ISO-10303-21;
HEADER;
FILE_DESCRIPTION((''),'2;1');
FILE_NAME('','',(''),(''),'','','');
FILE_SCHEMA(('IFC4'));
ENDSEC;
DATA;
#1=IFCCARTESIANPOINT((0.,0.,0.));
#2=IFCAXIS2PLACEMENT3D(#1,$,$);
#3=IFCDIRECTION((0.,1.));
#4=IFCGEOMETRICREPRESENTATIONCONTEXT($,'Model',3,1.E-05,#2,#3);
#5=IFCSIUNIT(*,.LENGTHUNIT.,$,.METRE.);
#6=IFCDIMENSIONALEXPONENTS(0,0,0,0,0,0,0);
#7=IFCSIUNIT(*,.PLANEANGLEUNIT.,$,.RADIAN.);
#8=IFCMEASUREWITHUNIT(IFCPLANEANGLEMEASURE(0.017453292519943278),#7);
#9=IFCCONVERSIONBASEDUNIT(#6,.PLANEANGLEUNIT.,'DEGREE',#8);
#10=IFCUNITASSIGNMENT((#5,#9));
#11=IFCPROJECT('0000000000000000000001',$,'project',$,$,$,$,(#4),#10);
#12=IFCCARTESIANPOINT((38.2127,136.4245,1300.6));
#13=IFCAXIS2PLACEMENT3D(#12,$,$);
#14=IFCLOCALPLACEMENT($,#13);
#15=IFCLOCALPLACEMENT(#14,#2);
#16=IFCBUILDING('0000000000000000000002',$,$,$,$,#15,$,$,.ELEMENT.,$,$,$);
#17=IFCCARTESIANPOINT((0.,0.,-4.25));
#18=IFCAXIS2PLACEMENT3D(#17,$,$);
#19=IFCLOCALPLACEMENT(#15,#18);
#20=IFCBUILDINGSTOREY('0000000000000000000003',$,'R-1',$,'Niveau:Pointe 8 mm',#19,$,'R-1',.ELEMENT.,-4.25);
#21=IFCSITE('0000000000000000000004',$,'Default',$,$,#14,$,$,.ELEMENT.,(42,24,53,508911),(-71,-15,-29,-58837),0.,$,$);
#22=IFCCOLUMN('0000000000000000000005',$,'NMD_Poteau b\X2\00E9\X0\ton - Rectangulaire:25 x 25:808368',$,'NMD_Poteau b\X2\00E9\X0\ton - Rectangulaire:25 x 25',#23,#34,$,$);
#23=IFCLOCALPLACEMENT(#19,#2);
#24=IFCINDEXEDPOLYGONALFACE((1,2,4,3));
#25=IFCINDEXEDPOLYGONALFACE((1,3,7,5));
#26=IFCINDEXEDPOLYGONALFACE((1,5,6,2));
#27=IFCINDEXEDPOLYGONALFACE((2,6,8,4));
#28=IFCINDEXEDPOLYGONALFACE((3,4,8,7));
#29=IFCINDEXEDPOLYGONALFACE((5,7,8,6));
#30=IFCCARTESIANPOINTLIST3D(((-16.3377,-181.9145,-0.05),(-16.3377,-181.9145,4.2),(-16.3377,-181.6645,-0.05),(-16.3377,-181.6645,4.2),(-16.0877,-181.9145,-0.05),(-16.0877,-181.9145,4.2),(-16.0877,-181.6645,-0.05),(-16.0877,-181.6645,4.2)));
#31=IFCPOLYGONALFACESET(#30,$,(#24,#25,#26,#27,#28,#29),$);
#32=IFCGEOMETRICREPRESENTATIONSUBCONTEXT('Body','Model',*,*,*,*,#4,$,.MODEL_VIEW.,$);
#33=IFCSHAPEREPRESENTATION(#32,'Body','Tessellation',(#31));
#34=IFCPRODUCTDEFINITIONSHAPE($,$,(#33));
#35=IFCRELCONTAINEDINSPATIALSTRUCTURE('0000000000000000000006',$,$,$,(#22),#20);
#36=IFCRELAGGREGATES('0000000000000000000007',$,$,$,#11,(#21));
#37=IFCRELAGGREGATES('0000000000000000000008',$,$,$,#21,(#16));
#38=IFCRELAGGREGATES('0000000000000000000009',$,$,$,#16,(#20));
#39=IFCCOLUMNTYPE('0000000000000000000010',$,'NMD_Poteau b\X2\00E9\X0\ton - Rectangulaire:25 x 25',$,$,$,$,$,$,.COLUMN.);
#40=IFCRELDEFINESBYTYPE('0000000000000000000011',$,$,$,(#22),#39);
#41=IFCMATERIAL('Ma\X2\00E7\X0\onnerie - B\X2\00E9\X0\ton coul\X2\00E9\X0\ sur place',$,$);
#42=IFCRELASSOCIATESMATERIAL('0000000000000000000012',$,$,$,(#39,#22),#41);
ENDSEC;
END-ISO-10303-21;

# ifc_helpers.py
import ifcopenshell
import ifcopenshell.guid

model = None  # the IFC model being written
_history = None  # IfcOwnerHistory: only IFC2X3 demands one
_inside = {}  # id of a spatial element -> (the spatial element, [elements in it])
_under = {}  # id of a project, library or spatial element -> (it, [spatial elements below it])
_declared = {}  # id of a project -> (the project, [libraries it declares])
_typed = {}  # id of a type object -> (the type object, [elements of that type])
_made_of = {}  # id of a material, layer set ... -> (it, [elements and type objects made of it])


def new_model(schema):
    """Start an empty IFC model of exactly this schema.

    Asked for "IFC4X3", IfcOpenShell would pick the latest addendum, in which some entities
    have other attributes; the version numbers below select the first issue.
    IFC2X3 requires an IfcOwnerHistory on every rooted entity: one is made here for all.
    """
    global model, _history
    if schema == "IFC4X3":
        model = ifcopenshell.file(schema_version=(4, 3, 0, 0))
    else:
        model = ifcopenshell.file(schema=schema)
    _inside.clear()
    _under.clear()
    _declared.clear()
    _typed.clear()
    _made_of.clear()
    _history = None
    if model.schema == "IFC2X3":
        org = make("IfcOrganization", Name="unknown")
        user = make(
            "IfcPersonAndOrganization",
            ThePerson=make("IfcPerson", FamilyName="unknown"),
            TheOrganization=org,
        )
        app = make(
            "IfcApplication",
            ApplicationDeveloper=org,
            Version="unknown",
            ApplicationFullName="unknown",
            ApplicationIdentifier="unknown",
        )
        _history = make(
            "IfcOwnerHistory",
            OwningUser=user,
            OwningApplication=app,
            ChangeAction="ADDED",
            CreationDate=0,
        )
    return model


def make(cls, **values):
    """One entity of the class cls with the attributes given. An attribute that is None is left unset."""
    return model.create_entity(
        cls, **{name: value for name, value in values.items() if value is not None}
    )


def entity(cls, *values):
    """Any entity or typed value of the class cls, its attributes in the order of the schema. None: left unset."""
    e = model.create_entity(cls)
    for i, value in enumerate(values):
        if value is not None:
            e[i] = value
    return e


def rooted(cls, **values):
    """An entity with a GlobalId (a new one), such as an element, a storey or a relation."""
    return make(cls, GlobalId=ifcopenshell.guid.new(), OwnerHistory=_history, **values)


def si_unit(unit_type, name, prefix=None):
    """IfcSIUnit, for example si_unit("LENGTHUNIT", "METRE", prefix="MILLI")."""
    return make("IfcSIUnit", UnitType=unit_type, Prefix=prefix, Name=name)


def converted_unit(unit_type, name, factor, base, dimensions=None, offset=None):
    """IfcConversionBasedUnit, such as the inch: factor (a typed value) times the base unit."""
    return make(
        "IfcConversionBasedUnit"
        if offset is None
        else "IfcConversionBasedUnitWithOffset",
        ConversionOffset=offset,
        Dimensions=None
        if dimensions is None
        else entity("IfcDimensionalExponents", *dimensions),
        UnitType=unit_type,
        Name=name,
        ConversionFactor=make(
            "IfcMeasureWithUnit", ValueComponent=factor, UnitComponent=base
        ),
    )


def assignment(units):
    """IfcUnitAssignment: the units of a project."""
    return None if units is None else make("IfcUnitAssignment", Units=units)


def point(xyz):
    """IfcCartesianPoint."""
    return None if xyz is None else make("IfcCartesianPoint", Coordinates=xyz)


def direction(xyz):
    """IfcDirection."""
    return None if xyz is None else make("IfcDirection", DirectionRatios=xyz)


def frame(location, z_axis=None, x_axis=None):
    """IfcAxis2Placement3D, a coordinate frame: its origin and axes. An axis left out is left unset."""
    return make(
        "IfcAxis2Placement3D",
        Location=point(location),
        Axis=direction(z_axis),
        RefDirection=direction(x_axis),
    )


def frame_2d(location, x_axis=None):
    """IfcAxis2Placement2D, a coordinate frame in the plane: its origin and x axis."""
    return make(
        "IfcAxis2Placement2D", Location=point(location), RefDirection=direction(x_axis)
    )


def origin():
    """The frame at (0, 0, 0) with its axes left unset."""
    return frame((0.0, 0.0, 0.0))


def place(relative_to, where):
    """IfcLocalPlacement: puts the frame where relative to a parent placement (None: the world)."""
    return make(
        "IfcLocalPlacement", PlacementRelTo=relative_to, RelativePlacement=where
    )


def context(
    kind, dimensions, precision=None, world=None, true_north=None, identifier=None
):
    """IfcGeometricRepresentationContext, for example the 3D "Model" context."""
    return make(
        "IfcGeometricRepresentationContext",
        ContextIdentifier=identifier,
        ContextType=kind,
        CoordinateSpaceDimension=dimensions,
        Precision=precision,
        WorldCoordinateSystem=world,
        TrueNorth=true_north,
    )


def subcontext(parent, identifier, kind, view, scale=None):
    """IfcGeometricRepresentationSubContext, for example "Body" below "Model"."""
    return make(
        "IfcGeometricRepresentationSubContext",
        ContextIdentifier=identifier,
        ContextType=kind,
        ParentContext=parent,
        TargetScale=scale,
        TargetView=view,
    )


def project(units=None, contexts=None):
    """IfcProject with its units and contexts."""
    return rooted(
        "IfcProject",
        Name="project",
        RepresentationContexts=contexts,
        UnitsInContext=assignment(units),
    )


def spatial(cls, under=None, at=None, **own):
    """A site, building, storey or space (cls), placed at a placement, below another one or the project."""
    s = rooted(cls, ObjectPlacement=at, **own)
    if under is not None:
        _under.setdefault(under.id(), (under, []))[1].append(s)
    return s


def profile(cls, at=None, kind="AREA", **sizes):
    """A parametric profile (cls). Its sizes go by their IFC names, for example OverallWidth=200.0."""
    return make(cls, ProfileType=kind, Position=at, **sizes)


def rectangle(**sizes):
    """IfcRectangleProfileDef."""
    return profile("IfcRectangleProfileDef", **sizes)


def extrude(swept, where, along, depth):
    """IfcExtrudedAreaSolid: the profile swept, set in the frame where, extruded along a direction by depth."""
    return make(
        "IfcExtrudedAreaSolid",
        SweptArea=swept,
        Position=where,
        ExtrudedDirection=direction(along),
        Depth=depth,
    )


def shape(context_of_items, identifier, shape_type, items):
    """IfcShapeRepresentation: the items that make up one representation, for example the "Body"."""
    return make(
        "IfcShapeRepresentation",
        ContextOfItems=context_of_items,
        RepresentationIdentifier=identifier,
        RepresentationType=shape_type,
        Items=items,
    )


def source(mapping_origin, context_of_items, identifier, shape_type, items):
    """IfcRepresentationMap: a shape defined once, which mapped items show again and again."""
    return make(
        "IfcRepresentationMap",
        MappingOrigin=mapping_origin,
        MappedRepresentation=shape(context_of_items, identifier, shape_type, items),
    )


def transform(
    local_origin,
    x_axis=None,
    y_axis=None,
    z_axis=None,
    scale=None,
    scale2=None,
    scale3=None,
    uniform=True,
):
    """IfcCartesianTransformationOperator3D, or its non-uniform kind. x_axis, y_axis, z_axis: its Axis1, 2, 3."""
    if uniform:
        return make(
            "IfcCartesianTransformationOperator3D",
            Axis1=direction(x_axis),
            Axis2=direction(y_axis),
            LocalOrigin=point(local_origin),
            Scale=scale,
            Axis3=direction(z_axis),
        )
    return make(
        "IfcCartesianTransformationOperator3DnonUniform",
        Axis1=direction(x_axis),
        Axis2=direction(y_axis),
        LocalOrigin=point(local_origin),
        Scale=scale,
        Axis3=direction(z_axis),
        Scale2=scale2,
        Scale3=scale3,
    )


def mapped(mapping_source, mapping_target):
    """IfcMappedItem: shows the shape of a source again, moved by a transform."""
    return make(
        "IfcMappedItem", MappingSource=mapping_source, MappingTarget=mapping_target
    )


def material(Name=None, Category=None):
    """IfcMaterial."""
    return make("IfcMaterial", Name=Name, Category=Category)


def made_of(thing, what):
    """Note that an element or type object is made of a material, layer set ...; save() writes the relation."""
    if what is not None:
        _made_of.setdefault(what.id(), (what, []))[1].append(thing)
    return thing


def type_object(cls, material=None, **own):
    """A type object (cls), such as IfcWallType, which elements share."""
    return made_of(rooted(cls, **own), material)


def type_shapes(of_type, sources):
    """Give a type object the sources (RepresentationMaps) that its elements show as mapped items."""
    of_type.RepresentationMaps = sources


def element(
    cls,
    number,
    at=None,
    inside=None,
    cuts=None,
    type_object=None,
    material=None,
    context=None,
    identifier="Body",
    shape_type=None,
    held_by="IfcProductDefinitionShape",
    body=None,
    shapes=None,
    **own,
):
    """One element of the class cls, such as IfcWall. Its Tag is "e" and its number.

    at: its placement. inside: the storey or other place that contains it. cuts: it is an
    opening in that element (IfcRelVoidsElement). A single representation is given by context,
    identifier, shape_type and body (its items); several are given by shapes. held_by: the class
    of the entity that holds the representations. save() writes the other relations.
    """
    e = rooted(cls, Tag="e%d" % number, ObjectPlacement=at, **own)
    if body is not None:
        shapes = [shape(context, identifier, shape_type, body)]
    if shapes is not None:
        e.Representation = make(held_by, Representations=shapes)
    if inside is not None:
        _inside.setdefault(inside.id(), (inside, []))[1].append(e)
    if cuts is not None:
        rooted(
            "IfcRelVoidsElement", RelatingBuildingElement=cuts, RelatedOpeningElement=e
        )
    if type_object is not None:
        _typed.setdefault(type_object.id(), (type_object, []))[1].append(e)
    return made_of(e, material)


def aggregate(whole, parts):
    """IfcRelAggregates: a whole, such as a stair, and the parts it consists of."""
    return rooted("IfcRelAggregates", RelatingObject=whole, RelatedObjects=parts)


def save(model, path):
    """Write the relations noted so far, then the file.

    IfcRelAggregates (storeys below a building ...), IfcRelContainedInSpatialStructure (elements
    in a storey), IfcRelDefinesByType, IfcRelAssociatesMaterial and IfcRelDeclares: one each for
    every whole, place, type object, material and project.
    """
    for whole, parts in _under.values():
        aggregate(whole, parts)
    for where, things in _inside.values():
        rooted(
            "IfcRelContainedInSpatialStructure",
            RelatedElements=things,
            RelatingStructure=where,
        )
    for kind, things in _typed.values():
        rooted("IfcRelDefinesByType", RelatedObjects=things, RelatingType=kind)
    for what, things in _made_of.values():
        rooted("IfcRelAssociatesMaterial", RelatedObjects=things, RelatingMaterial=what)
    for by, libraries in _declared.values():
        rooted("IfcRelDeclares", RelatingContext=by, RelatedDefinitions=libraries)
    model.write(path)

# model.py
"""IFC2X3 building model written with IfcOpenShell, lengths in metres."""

from ifc_helpers import new_model, entity, si_unit, converted_unit, direction, frame, frame_2d, origin, place, context, subcontext, project, spatial, rectangle, extrude, source, transform, mapped, material, type_object, type_shapes, element, save


model = new_model("IFC2X3")

# Units and contexts
model_context = context("Model", 3, precision=1e-05, world=origin(), true_north=direction((0.0, 1.0)))
body_context = subcontext(model_context, "Body", "Model", "MODEL_VIEW")
ifc_project = project(units=[si_unit("LENGTHUNIT", "METRE"), converted_unit("PLANEANGLEUNIT", "DEGREE", entity("IfcPlaneAngleMeasure", 0.017453292519943278), si_unit("PLANEANGLEUNIT", "RADIAN"), dimensions=[0, 0, 0, 0, 0, 0, 0])], contexts=[model_context])

# Site, building, storey
site_placement = place(None, frame((38.2127, 136.4245, 1300.6)))
site = spatial("IfcSite", under=ifc_project, at=site_placement, Name="Default", CompositionType="ELEMENT", RefLatitude=(42, 24, 53, 508911), RefLongitude=(-71, -15, -29, -58837), RefElevation=0.0)
building_placement = place(site_placement, origin())
building = spatial("IfcBuilding", under=site, at=building_placement, CompositionType="ELEMENT")
storey_placement = place(building_placement, frame((0.0, 0.0, -4.25)))
storey = spatial("IfcBuildingStorey", under=building, at=storey_placement, Name="R-1", ObjectType="Niveau:Pointe 8 mm", LongName="R-1", CompositionType="ELEMENT", Elevation=-4.25)

# Column
ifc_material = material(Name="Maçonnerie - Béton coulé sur place")
column_type_1 = type_object("IfcColumnType", Name="NMD_Poteau béton - Rectangulaire:25 x 25", PredefinedType="COLUMN", material=ifc_material)
shared_shape_1 = source(origin(), body_context, "Body", "SweptSolid", [
    extrude(rectangle(XDim=0.25, YDim=0.25, at=frame_2d((0.0, 0.0), x_axis=(1.0, 0.0))), frame((-16.2127, -181.7895, -4.3), z_axis=(0.0, 0.0, 1.0), x_axis=(-1.0, 0.0, 0.0)), (0.0, 0.0, 1.0), 4.25),
])
type_shapes(column_type_1, [shared_shape_1])
column_1_placement = place(storey_placement, frame((0.0, 0.0, 4.25)))
element("IfcColumn", 1, at=column_1_placement, inside=storey, type_object=column_type_1, material=ifc_material, Name="NMD_Poteau béton - Rectangulaire:25 x 25:808368", ObjectType="NMD_Poteau béton - Rectangulaire:25 x 25", context=body_context, shape_type="MappedRepresentation", body=[
    mapped(shared_shape_1, transform((0.0, 0.0, 0.0), scale=1.0)),
])

save(model, "model.ifc")
